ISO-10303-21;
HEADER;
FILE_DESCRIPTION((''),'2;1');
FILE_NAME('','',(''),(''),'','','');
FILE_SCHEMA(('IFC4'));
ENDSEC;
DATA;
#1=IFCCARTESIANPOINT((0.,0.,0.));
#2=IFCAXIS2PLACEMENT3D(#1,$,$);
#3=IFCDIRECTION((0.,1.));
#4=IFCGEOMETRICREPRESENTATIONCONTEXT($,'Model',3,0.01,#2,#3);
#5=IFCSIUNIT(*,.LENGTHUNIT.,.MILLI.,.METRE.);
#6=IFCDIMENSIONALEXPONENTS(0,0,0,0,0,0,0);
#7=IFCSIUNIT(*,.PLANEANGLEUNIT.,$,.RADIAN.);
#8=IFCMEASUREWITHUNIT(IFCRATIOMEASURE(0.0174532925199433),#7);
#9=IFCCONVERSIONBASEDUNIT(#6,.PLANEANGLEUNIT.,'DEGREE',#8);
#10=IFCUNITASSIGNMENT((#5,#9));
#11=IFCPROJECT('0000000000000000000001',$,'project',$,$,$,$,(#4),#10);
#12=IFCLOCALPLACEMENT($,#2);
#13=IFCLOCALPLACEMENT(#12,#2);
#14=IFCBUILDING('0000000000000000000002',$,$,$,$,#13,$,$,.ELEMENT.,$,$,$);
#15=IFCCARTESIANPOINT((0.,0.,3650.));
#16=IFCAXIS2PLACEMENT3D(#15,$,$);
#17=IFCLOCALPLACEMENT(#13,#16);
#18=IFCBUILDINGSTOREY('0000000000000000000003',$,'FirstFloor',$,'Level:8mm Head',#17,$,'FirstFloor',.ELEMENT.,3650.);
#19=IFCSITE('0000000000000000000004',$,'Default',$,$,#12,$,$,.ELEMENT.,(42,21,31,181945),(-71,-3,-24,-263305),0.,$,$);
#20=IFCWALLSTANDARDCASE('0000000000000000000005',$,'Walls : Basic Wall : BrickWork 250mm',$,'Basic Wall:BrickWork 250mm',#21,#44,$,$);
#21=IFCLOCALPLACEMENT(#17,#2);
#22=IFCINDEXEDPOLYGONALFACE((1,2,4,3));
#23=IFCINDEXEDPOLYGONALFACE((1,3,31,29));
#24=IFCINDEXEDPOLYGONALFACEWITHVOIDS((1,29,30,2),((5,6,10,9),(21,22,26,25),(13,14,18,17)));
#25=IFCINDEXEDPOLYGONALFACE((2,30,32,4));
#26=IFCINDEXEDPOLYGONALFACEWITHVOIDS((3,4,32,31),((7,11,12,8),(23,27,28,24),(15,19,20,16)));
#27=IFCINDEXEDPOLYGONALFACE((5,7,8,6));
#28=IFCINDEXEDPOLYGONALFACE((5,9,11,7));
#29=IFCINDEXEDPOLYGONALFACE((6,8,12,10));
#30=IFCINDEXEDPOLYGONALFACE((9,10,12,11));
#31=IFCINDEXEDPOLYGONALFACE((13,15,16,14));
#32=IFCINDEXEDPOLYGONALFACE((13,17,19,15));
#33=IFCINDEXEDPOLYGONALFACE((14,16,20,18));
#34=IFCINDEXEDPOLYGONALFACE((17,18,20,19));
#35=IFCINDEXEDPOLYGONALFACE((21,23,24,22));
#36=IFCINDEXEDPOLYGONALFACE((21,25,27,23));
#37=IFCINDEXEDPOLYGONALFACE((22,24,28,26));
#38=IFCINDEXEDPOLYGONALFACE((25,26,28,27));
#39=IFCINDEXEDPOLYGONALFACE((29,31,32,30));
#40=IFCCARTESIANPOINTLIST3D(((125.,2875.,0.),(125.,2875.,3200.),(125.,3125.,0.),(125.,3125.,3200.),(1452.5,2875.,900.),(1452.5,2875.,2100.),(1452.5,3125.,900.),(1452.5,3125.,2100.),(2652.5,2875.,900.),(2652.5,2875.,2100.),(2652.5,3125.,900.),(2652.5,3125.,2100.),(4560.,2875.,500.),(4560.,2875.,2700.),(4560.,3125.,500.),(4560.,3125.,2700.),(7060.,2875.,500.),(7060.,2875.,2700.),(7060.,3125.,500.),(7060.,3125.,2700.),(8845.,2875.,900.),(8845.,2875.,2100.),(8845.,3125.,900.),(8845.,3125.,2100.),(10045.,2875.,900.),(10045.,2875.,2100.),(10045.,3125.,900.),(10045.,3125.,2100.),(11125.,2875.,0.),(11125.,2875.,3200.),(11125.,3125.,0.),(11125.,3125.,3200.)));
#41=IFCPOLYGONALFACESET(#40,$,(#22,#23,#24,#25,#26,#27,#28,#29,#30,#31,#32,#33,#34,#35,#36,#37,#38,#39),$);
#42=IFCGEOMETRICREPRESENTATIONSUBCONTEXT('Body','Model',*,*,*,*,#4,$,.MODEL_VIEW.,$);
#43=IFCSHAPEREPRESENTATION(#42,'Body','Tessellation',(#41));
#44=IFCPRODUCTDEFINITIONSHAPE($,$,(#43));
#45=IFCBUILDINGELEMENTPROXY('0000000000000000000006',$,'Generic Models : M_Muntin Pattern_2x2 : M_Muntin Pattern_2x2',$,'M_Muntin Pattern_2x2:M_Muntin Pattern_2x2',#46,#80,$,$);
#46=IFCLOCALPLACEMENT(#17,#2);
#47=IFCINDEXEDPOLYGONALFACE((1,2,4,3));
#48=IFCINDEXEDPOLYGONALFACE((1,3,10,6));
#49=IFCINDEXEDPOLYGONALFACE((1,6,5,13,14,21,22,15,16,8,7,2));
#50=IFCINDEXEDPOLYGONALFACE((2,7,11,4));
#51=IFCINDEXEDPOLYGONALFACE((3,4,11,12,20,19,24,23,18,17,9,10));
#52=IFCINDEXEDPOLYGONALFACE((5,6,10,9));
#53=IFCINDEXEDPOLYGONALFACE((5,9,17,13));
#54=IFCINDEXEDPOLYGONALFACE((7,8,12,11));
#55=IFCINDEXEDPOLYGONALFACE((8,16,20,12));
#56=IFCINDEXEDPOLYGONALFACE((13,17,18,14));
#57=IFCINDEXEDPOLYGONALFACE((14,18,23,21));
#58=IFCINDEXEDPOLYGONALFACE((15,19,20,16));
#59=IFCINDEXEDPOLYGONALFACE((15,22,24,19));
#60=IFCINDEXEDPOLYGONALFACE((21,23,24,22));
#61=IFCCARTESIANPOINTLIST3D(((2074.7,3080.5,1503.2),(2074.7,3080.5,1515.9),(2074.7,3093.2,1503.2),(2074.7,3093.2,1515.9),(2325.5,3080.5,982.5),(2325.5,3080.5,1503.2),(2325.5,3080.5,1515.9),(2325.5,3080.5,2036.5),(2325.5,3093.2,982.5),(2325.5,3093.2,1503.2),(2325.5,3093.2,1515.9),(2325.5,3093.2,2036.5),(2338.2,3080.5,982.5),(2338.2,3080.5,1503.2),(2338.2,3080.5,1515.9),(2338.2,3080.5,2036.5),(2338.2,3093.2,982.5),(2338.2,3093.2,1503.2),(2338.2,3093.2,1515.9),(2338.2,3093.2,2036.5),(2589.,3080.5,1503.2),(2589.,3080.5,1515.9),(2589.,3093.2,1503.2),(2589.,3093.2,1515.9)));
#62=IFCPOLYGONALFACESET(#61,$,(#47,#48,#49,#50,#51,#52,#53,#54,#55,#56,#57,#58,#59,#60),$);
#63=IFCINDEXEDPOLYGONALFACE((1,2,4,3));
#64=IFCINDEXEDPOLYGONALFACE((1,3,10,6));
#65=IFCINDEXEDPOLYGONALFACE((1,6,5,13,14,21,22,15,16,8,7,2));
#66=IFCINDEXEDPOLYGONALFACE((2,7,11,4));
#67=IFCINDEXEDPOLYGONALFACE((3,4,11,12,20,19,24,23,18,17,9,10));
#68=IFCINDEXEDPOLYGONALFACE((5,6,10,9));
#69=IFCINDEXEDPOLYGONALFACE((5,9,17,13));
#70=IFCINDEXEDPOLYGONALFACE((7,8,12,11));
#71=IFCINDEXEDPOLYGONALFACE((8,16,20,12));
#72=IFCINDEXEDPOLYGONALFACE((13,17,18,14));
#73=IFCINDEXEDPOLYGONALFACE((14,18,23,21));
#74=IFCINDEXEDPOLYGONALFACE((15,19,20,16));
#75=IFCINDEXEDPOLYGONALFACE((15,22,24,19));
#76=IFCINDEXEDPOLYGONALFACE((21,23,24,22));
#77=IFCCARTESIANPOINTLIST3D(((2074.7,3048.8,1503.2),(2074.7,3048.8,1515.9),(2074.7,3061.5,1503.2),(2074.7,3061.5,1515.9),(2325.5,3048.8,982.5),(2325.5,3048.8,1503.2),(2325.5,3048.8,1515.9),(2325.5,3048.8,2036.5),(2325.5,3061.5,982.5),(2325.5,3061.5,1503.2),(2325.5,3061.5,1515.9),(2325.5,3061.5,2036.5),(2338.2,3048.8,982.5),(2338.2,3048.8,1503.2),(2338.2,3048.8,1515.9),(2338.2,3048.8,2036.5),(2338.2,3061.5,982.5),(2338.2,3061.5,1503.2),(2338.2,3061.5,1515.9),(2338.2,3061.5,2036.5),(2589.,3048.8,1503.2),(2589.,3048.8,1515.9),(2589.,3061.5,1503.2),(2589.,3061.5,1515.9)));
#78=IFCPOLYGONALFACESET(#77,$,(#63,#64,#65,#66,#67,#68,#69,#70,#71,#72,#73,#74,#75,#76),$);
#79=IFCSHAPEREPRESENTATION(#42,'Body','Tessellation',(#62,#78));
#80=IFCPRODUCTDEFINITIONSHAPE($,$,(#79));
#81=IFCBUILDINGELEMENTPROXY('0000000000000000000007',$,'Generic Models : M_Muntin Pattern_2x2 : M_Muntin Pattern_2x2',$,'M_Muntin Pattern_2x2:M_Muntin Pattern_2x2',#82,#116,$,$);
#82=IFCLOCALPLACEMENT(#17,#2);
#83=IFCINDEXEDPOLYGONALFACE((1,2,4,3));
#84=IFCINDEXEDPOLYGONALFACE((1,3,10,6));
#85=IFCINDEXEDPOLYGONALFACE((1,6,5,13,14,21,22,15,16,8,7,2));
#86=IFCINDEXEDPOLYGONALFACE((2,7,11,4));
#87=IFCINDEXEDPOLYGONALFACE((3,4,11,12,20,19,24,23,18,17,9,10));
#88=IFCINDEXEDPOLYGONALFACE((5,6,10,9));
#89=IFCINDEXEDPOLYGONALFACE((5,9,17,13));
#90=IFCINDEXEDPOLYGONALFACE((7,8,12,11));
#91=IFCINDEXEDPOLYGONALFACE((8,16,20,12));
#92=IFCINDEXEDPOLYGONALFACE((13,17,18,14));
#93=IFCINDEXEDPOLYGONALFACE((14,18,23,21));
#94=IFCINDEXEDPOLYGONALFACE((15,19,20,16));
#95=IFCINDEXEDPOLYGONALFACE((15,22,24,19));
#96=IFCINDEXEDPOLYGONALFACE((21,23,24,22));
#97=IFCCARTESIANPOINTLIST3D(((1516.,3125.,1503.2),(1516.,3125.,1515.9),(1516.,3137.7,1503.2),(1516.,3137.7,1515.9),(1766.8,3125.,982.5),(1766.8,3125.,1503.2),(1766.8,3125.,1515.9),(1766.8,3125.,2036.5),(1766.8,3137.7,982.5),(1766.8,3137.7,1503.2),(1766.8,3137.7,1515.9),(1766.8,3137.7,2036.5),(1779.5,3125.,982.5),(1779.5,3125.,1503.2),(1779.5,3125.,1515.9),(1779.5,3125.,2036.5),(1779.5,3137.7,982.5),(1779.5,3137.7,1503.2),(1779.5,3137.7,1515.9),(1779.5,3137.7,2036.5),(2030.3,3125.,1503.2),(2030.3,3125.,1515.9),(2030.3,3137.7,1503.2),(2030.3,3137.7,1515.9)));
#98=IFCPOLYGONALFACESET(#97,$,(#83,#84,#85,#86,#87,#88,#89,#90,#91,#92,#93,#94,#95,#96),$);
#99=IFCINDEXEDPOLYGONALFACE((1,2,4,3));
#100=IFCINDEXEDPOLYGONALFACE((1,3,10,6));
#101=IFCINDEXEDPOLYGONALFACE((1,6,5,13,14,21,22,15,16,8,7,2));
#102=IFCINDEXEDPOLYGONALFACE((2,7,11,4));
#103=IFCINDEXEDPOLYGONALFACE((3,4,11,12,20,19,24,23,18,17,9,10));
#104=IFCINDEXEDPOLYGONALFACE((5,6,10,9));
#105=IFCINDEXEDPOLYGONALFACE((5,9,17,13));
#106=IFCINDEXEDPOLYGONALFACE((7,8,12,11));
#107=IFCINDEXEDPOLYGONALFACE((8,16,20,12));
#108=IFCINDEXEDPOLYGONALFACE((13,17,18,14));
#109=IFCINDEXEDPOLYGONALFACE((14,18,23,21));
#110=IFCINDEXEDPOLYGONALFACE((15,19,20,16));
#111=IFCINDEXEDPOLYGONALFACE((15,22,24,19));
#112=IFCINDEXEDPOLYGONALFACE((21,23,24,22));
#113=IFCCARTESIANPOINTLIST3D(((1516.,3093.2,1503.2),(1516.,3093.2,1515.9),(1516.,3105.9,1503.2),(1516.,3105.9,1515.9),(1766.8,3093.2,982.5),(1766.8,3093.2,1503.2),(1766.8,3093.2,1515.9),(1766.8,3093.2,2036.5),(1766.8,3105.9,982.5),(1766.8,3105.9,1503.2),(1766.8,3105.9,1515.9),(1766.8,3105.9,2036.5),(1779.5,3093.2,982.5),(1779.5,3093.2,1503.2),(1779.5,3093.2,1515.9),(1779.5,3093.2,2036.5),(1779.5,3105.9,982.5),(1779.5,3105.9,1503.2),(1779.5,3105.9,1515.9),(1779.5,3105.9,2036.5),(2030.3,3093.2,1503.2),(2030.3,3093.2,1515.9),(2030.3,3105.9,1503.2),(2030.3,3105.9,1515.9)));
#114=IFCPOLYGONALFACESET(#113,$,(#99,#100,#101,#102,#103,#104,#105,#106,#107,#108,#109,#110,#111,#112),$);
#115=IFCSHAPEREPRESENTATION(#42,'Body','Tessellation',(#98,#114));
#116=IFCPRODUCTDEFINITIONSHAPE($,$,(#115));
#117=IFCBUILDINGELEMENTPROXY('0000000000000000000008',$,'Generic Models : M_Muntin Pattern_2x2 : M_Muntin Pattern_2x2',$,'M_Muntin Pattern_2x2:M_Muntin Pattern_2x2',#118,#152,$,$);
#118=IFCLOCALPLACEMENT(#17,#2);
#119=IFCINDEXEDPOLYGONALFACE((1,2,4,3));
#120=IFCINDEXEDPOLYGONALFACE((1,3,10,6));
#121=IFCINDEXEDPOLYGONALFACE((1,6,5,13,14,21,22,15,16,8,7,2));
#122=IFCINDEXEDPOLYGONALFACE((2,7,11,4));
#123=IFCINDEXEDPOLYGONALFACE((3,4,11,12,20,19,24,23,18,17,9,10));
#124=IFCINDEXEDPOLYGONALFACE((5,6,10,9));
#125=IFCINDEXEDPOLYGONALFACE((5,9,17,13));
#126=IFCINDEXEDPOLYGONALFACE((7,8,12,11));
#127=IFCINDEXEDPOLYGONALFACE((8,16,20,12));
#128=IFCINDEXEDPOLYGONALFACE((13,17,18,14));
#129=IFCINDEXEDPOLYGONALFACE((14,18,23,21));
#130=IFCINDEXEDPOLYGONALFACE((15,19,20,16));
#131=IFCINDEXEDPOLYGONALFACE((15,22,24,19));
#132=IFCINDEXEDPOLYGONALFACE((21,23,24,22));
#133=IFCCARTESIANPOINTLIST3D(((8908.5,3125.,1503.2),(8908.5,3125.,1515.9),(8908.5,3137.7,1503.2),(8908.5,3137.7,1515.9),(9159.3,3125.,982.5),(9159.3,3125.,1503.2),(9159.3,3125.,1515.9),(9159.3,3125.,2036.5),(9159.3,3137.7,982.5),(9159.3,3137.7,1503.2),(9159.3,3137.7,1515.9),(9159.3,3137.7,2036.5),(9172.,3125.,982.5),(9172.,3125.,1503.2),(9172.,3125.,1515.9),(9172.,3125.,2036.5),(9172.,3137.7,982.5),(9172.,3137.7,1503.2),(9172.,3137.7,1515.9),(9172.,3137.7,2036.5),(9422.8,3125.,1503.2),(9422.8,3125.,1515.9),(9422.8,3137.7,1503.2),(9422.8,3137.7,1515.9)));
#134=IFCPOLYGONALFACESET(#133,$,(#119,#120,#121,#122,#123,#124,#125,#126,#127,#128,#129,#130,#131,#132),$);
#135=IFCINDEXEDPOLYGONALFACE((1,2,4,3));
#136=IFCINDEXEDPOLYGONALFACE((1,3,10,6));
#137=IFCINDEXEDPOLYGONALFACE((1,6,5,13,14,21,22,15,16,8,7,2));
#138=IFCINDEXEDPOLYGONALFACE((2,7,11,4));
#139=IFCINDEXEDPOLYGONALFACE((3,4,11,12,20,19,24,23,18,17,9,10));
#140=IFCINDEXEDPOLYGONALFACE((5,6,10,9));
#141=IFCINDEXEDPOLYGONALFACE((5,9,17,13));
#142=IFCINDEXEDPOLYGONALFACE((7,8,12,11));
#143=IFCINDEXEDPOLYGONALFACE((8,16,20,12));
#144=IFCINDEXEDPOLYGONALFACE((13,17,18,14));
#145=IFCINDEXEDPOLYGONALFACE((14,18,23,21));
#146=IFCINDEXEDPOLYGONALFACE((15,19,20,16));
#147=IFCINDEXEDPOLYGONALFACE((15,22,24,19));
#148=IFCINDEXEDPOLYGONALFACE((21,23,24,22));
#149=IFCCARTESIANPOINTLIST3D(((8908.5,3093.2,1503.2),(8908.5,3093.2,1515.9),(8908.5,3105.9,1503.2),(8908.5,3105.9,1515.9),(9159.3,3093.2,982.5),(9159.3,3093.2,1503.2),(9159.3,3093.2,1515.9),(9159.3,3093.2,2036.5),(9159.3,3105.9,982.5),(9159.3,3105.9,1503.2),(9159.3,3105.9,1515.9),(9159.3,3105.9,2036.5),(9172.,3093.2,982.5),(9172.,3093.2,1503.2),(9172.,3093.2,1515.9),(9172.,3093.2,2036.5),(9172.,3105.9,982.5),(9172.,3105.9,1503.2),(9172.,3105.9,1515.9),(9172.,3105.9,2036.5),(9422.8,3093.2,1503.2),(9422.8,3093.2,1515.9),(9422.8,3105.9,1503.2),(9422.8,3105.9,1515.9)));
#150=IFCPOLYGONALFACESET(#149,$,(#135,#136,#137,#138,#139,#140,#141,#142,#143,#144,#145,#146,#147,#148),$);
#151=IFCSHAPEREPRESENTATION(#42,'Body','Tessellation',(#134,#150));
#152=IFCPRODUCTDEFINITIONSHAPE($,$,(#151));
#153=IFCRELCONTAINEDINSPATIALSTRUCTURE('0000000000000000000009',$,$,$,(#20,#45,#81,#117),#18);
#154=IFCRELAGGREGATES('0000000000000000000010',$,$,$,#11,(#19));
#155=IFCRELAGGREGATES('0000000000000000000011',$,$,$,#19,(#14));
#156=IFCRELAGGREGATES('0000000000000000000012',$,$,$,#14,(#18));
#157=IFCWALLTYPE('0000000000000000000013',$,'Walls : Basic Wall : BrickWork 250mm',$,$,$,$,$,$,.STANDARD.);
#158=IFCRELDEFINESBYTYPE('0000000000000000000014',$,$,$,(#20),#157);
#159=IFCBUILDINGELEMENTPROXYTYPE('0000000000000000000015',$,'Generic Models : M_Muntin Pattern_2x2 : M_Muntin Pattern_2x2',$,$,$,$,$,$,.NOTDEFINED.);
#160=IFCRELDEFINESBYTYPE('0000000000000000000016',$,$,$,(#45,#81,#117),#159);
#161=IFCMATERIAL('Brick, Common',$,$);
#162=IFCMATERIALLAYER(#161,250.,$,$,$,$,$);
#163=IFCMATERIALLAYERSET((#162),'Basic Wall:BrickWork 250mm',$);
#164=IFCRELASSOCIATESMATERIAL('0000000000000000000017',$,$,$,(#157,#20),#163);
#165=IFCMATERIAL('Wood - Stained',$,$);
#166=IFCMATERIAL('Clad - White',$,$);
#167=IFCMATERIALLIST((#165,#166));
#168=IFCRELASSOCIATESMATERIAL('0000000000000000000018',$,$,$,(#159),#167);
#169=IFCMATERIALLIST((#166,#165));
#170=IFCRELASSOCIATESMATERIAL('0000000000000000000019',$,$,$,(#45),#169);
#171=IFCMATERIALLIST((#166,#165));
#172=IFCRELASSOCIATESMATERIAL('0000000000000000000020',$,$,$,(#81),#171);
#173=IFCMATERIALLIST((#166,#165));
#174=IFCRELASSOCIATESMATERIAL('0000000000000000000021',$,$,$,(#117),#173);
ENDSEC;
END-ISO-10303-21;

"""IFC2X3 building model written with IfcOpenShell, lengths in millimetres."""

from ifc_helpers import new_model, entity, si_unit, converted_unit, direction, frame, frame_2d, origin, place, context, subcontext, project, spatial, polyline, rectangle, outline, extrude, clip, halfspace, source, transform, mapped, material, material_list, layer, layer_set, layer_usage, type_object, type_shapes, element, save


model = new_model("IFC2X3")

# Units and contexts
model_context = context("Model", 3, precision=0.01, world=origin(), true_north=direction((0.0, 1.0)))
body_context = subcontext(model_context, "Body", "Model", "MODEL_VIEW")
ifc_project = project(units=[si_unit("LENGTHUNIT", "METRE", prefix="MILLI"), converted_unit("PLANEANGLEUNIT", "DEGREE", entity("IfcRatioMeasure", 0.0174532925199433), si_unit("PLANEANGLEUNIT", "RADIAN"), dimensions=[0, 0, 0, 0, 0, 0, 0])], contexts=[model_context])

# Site, building, storey
site_placement = place(None, origin())
site = spatial("IfcSite", under=ifc_project, at=site_placement, Name="Default", CompositionType="ELEMENT", RefLatitude=(42, 21, 31, 181945), RefLongitude=(-71, -3, -24, -263305), RefElevation=0.0)
building_placement = place(site_placement, origin())
building = spatial("IfcBuilding", under=site, at=building_placement, CompositionType="ELEMENT")
storey_placement = place(building_placement, frame((0.0, 0.0, 3650.0)))
storey = spatial("IfcBuildingStorey", under=building, at=storey_placement, Name="FirstFloor", ObjectType="Level:8mm Head", LongName="FirstFloor", CompositionType="ELEMENT", Elevation=3650.0)

# Shared definitions
ifc_material_1 = material(Name="Brick, Common")
ifc_layer = layer(ifc_material_1, 250.0)
ifc_layer_set = layer_set([ifc_layer], Name="Basic Wall:BrickWork 250mm")
wall_type = type_object("IfcWallType", Name="Walls : Basic Wall : BrickWork 250mm", PredefinedType="STANDARD", material=ifc_layer_set)

# Wall, openings
ifc_layer_usage_1 = layer_usage(ifc_layer_set, "AXIS2", "POSITIVE", -125.0)
wall_1_placement = place(storey_placement, frame((125.0, 3000.0, 0.0)))
wall_1 = element("IfcWallStandardCase", 1, at=wall_1_placement, inside=storey, type_object=wall_type, material=ifc_layer_usage_1, Name="Walls : Basic Wall : BrickWork 250mm", ObjectType="Basic Wall:BrickWork 250mm", context=body_context, shape_type="Clipping", body=[
    clip(extrude(rectangle(XDim=11000.0, YDim=250.0, at=frame_2d((5500.0, 0.0), x_axis=(-1.0, 0.0))), origin(), (0.0, 0.0, 1.0), 3200.0), halfspace(frame((0.0, 0.0, -3200.0)), True)),
])
opening_1_placement = place(wall_1_placement, origin())
element("IfcOpeningElement", 2, at=opening_1_placement, cuts=wall_1, ObjectType="Opening", context=body_context, shape_type="SweptSolid", body=[
    extrude(rectangle(XDim=2200.0, YDim=2500.0, at=frame_2d((0.0, 0.0), x_axis=(1.0, 0.0))), frame((5685.0, -277.4, 1600.0), z_axis=(0.0, 1.0, 0.0), x_axis=(0.0, 0.0, 1.0)), (0.0, 0.0, 1.0), 554.8),
])
opening_2_placement = place(wall_1_placement, frame((1327.5, -125.0, 900.0)))
element("IfcOpeningElement", 3, at=opening_2_placement, cuts=wall_1, ObjectType="Opening", context=body_context, shape_type="SweptSolid", body=[
    extrude(rectangle(XDim=1200.0, YDim=1200.0, at=frame_2d((600.0, 600.0), x_axis=(-1.0, 0.0))), frame((0.0, 0.0, 0.0), z_axis=(0.0, 1.0, 0.0), x_axis=(0.0, 0.0, 1.0)), (0.0, 0.0, 1.0), 250.0),
])
opening_3_placement = place(wall_1_placement, frame((8720.0, -125.0, 900.0)))
element("IfcOpeningElement", 4, at=opening_3_placement, cuts=wall_1, ObjectType="Opening", context=body_context, shape_type="SweptSolid", body=[
    extrude(rectangle(XDim=1200.0, YDim=1200.0, at=frame_2d((600.0, 600.0), x_axis=(-1.0, 0.0))), frame((0.0, 0.0, 0.0), z_axis=(0.0, 1.0, 0.0), x_axis=(0.0, 0.0, 1.0)), (0.0, 0.0, 1.0), 250.0),
])

# Building element proxies
ifc_material_2 = material(Name="Clad - White")
ifc_material_3 = material(Name="Wood - Stained")
ifc_material_list_1 = material_list([ifc_material_2, ifc_material_3])
ifc_material_list_2 = material_list([ifc_material_3, ifc_material_2])
building_element_proxy_type_1 = type_object("IfcBuildingElementProxyType", Name="Generic Models : M_Muntin Pattern_2x2 : M_Muntin Pattern_2x2", PredefinedType="NOTDEFINED", material=ifc_material_list_2)
shared_shape_1 = source(origin(), body_context, "Body", "SweptSolid", [
    extrude(outline(polyline([(6.4, -6.4), (527.0, -6.4), (527.0, 6.3), (6.4, 6.3), (6.4, 257.1), (-6.3, 257.1), (-6.3, 6.3), (-527.0, 6.3), (-527.0, -6.4), (-6.3, -6.4), (-6.3, -257.1), (6.4, -257.1), (6.4, -6.4)])), frame((0.0, 9.5, 527.0), z_axis=(0.0, 1.0, 0.0), x_axis=(0.0, 0.0, 1.0)), (0.0, 0.0, 1.0), 12.7),
    extrude(outline(polyline([(6.4, -6.4), (527.0, -6.4), (527.0, 6.3), (6.4, 6.3), (6.4, 257.1), (-6.3, 257.1), (-6.3, 6.3), (-527.0, 6.3), (-527.0, -6.4), (-6.3, -6.4), (-6.3, -257.1), (6.4, -257.1), (6.4, -6.4)])), frame((0.0, -22.2, 527.0), z_axis=(0.0, 1.0, 0.0), x_axis=(0.0, 0.0, 1.0)), (0.0, 0.0, 1.0), 12.7),
])
type_shapes(building_element_proxy_type_1, [shared_shape_1])
proxy_1_placement = place(storey_placement, frame((2331.9, 3071.0, 982.5)))
element("IfcBuildingElementProxy", 5, at=proxy_1_placement, inside=storey, type_object=building_element_proxy_type_1, material=ifc_material_list_1, Name="Generic Models : M_Muntin Pattern_2x2 : M_Muntin Pattern_2x2", ObjectType="M_Muntin Pattern_2x2:M_Muntin Pattern_2x2", context=body_context, shape_type="MappedRepresentation", body=[
    mapped(shared_shape_1, transform((0.0, 0.0, 0.0), scale=1.0)),
])
ifc_material_list_3 = material_list([ifc_material_2, ifc_material_3])
proxy_2_placement = place(storey_placement, frame((1773.1, 3115.5, 982.5)))
element("IfcBuildingElementProxy", 6, at=proxy_2_placement, inside=storey, type_object=building_element_proxy_type_1, material=ifc_material_list_3, Name="Generic Models : M_Muntin Pattern_2x2 : M_Muntin Pattern_2x2", ObjectType="M_Muntin Pattern_2x2:M_Muntin Pattern_2x2", context=body_context, shape_type="MappedRepresentation", body=[
    mapped(shared_shape_1, transform((0.0, 0.0, 0.0), scale=1.0)),
])
ifc_material_list_4 = material_list([ifc_material_2, ifc_material_3])
proxy_3_placement = place(storey_placement, frame((9165.6, 3115.5, 982.5)))
element("IfcBuildingElementProxy", 7, at=proxy_3_placement, inside=storey, type_object=building_element_proxy_type_1, material=ifc_material_list_4, Name="Generic Models : M_Muntin Pattern_2x2 : M_Muntin Pattern_2x2", ObjectType="M_Muntin Pattern_2x2:M_Muntin Pattern_2x2", context=body_context, shape_type="MappedRepresentation", body=[
    mapped(shared_shape_1, transform((0.0, 0.0, 0.0), scale=1.0)),
])

save(model, "model.ifc")
